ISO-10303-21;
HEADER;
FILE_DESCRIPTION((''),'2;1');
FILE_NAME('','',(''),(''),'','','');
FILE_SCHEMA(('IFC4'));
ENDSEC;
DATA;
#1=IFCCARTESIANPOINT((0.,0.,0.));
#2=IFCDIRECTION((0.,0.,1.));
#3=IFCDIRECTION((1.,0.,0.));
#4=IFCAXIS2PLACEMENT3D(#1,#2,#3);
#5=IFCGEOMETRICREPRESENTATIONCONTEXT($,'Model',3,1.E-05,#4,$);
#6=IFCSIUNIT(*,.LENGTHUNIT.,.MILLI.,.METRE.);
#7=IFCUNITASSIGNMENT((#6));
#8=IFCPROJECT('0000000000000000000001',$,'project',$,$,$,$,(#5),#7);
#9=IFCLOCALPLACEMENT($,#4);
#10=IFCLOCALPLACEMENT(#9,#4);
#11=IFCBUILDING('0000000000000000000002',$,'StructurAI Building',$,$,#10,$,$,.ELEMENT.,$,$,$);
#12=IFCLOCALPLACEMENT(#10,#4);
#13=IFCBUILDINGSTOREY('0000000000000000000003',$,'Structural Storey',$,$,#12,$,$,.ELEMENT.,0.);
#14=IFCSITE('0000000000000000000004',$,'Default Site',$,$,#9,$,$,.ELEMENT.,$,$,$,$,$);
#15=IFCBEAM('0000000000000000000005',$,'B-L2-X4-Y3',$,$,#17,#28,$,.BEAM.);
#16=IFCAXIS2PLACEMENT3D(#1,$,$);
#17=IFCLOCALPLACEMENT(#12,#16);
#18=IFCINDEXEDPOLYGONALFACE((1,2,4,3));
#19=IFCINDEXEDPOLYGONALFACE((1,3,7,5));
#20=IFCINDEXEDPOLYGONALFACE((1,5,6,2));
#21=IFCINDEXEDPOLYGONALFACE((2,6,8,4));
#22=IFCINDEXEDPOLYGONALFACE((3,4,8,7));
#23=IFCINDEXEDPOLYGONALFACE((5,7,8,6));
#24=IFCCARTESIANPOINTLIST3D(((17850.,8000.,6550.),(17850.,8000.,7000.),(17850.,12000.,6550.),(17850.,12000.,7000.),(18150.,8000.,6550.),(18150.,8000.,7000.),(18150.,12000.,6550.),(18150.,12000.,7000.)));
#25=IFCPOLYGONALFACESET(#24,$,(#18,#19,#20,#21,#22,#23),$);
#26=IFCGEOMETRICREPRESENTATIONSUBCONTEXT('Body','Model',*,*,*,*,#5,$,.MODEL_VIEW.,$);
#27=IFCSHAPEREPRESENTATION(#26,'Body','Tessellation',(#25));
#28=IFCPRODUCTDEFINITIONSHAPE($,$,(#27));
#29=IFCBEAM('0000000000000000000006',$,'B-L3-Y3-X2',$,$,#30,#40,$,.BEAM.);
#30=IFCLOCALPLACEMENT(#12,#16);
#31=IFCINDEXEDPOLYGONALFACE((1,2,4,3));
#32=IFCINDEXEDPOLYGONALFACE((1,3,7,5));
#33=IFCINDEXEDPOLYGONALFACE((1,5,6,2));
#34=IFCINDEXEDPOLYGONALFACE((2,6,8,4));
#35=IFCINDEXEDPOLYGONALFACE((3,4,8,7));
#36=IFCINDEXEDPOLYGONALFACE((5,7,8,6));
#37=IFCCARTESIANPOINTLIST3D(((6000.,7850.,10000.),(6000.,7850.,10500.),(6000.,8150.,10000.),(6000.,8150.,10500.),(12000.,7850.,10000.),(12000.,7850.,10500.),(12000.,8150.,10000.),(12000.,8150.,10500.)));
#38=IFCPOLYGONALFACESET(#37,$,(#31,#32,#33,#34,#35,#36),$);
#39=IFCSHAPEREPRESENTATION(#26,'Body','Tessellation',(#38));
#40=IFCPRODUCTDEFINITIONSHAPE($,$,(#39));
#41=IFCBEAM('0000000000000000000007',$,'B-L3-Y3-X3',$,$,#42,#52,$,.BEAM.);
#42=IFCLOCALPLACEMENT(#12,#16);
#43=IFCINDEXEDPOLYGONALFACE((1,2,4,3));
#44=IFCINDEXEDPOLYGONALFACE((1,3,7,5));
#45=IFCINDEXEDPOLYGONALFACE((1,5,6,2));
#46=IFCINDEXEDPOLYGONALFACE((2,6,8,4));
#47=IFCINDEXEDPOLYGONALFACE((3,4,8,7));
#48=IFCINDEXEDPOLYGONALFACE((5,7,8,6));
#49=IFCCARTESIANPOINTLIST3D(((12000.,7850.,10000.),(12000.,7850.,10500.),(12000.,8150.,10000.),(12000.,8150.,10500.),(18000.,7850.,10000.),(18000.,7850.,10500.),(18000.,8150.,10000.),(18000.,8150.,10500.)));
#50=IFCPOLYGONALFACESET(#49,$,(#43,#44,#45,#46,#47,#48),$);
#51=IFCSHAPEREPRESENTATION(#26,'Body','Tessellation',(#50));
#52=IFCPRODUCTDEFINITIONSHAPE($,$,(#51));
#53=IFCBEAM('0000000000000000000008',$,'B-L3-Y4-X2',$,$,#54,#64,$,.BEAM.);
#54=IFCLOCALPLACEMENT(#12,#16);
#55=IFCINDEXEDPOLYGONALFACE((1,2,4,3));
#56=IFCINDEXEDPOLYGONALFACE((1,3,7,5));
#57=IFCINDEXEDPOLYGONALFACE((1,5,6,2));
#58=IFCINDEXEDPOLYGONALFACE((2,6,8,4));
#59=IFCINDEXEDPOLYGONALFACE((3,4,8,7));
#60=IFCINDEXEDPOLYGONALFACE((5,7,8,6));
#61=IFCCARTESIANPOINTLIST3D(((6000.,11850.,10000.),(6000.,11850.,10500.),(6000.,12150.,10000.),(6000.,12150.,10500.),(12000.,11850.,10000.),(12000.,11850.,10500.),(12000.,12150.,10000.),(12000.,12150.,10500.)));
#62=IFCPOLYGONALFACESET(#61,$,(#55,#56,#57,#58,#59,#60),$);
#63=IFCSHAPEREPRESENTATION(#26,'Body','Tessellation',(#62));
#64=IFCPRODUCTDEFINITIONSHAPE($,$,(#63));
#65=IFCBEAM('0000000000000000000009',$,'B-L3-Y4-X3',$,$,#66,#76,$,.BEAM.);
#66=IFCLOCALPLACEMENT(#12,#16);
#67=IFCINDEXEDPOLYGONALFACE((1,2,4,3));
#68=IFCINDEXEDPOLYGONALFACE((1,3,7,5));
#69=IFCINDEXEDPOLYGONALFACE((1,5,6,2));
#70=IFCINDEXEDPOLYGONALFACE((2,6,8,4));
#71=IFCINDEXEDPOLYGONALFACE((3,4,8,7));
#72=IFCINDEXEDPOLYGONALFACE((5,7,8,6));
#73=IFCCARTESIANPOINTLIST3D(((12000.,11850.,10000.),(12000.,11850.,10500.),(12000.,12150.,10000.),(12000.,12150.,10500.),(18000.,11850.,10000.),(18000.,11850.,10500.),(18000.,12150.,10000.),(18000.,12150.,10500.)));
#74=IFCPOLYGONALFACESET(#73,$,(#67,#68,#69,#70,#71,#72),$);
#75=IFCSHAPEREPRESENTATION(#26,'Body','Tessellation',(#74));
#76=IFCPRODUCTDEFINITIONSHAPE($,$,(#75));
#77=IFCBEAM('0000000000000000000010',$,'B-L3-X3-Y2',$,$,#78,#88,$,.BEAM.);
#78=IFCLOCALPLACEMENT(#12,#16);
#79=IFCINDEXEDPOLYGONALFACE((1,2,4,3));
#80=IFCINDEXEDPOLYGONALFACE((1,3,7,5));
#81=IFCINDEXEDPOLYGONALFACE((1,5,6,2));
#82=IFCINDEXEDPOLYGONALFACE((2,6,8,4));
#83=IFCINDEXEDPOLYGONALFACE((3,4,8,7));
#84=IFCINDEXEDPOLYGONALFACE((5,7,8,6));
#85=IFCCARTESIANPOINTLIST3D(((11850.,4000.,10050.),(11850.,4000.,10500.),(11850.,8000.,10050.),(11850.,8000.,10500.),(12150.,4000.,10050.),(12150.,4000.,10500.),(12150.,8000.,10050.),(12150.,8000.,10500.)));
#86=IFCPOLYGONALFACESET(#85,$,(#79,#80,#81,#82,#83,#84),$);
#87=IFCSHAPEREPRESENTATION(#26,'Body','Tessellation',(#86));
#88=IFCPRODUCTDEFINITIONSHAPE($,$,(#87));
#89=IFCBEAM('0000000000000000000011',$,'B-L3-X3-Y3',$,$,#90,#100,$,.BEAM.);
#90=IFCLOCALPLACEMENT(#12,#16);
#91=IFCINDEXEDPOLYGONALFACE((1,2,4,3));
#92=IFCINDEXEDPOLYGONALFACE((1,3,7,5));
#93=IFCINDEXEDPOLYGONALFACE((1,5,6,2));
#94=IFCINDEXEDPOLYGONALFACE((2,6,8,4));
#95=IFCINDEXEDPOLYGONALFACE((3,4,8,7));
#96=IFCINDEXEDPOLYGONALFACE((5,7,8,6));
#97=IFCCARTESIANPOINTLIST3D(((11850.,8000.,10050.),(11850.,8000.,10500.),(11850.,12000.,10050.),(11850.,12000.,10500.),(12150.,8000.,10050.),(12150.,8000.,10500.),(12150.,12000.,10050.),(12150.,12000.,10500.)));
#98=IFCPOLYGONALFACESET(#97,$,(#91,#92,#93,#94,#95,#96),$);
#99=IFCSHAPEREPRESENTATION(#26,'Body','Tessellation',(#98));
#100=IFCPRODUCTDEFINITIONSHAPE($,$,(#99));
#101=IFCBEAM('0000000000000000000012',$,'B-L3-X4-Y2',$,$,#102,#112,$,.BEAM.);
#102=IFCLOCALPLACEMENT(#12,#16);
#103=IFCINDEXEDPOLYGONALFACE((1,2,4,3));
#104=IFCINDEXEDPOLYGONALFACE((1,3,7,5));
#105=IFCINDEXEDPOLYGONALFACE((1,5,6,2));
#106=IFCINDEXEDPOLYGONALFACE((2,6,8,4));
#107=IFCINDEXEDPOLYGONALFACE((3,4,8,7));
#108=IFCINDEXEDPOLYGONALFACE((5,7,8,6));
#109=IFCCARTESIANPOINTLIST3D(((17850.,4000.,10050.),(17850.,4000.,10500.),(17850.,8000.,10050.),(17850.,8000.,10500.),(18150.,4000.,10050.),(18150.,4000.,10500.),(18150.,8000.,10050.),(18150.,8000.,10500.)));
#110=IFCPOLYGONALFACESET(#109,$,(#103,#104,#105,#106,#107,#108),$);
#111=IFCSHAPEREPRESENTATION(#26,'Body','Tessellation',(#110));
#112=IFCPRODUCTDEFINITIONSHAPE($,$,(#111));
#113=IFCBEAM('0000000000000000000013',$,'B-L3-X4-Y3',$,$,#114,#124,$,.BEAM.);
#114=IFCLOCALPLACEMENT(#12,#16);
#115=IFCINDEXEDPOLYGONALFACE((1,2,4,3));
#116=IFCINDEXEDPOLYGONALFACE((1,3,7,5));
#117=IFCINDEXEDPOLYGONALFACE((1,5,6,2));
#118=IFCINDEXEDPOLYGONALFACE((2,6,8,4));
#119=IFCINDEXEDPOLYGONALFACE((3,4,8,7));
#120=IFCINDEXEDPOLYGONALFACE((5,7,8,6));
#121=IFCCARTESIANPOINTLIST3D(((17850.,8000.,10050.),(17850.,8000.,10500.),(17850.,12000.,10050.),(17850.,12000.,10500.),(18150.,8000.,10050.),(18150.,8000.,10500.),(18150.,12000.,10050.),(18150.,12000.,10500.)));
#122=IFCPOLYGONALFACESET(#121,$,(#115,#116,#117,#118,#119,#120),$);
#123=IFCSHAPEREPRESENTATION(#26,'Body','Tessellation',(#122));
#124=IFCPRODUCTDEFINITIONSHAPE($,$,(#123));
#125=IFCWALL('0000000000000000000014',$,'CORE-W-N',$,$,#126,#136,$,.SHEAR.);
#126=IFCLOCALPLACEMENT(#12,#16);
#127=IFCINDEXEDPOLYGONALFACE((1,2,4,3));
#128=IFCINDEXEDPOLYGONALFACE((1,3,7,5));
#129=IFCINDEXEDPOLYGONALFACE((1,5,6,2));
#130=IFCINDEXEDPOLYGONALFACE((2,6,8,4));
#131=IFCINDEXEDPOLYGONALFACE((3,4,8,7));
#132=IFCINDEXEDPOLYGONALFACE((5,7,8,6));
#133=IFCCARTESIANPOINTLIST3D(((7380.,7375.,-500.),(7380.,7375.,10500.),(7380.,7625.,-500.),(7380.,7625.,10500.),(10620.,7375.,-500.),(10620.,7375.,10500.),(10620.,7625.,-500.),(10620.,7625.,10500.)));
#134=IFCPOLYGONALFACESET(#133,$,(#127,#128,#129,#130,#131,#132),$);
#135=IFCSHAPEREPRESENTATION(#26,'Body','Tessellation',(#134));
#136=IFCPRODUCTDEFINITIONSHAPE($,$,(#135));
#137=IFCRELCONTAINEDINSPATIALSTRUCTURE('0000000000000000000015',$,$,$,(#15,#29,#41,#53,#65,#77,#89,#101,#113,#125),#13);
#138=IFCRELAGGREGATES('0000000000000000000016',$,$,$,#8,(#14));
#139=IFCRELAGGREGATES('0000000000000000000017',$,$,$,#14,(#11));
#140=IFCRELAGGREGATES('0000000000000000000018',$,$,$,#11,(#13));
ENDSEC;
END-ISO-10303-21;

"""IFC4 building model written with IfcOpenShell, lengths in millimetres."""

from ifc_helpers import new_model, si_unit, frame, origin_with_axes, place, context, subcontext, project, spatial, rectangle, extrude, element, save


model = new_model("IFC4")

# Units and contexts
model_context = context("Model", 3, precision=1e-05, world=origin_with_axes())
body_context = subcontext(model_context, "Body", "Model", "MODEL_VIEW")
ifc_project = project(units=[si_unit("LENGTHUNIT", "METRE", prefix="MILLI")], contexts=[model_context])

# Site, building, storey
site_placement = place(None, origin_with_axes())
site = spatial("IfcSite", under=ifc_project, at=site_placement, Name="Default Site", CompositionType="ELEMENT")
building_placement = place(site_placement, origin_with_axes())
building = spatial("IfcBuilding", under=site, at=building_placement, Name="StructurAI Building", CompositionType="ELEMENT")
storey_placement = place(building_placement, origin_with_axes())
storey = spatial("IfcBuildingStorey", under=building, at=storey_placement, Name="Structural Storey", CompositionType="ELEMENT", Elevation=0.0)

# Beams
for number, where, z_axis, x_axis, name in (
    (1, (18000.0, 10000.0, 6550.0), (0.0, 0.0, 1.0), (0.0, 1.0, 0.0), "B-L2-X4-Y3"),
):
    element("IfcBeam", number, at=place(storey_placement, frame(where, z_axis=z_axis, x_axis=x_axis)), inside=storey, Name=name, PredefinedType="BEAM", context=body_context, shape_type="SweptSolid", body=[
        extrude(rectangle(XDim=4000.0, YDim=300.0), origin_with_axes(), (0.0, 0.0, 1.0), 450.0),
    ])
for number, where, z_axis, x_axis, name in (
    (2, (9000.0, 8000.0, 10000.0), (0.0, 0.0, 1.0), (1.0, 0.0, 0.0), "B-L3-Y3-X2"),
    (3, (15000.0, 8000.0, 10000.0), (0.0, 0.0, 1.0), (1.0, 0.0, 0.0), "B-L3-Y3-X3"),
    (4, (9000.0, 12000.0, 10000.0), (0.0, 0.0, 1.0), (1.0, 0.0, 0.0), "B-L3-Y4-X2"),
    (5, (15000.0, 12000.0, 10000.0), (0.0, 0.0, 1.0), (1.0, 0.0, 0.0), "B-L3-Y4-X3"),
):
    element("IfcBeam", number, at=place(storey_placement, frame(where, z_axis=z_axis, x_axis=x_axis)), inside=storey, Name=name, PredefinedType="BEAM", context=body_context, shape_type="SweptSolid", body=[
        extrude(rectangle(XDim=6000.0, YDim=300.0), origin_with_axes(), (0.0, 0.0, 1.0), 500.0),
    ])
for number, where, z_axis, x_axis, name in (
    (6, (12000.0, 6000.0, 10050.0), (0.0, 0.0, 1.0), (0.0, 1.0, 0.0), "B-L3-X3-Y2"),
    (7, (12000.0, 10000.0, 10050.0), (0.0, 0.0, 1.0), (0.0, 1.0, 0.0), "B-L3-X3-Y3"),
    (8, (18000.0, 6000.0, 10050.0), (0.0, 0.0, 1.0), (0.0, 1.0, 0.0), "B-L3-X4-Y2"),
    (9, (18000.0, 10000.0, 10050.0), (0.0, 0.0, 1.0), (0.0, 1.0, 0.0), "B-L3-X4-Y3"),
):
    element("IfcBeam", number, at=place(storey_placement, frame(where, z_axis=z_axis, x_axis=x_axis)), inside=storey, Name=name, PredefinedType="BEAM", context=body_context, shape_type="SweptSolid", body=[
        extrude(rectangle(XDim=4000.0, YDim=300.0), origin_with_axes(), (0.0, 0.0, 1.0), 450.0),
    ])

# Wall
wall_placement = place(storey_placement, frame((9000.0, 7500.0, -500.0), z_axis=(0.0, 0.0, 1.0), x_axis=(1.0, 0.0, 0.0)))
element("IfcWall", 10, at=wall_placement, inside=storey, Name="CORE-W-N", PredefinedType="SHEAR", context=body_context, shape_type="SweptSolid", body=[
    extrude(rectangle(XDim=3240.0, YDim=250.0), origin_with_axes(), (0.0, 0.0, 1.0), 11000.0),
])

save(model, "model.ifc")
